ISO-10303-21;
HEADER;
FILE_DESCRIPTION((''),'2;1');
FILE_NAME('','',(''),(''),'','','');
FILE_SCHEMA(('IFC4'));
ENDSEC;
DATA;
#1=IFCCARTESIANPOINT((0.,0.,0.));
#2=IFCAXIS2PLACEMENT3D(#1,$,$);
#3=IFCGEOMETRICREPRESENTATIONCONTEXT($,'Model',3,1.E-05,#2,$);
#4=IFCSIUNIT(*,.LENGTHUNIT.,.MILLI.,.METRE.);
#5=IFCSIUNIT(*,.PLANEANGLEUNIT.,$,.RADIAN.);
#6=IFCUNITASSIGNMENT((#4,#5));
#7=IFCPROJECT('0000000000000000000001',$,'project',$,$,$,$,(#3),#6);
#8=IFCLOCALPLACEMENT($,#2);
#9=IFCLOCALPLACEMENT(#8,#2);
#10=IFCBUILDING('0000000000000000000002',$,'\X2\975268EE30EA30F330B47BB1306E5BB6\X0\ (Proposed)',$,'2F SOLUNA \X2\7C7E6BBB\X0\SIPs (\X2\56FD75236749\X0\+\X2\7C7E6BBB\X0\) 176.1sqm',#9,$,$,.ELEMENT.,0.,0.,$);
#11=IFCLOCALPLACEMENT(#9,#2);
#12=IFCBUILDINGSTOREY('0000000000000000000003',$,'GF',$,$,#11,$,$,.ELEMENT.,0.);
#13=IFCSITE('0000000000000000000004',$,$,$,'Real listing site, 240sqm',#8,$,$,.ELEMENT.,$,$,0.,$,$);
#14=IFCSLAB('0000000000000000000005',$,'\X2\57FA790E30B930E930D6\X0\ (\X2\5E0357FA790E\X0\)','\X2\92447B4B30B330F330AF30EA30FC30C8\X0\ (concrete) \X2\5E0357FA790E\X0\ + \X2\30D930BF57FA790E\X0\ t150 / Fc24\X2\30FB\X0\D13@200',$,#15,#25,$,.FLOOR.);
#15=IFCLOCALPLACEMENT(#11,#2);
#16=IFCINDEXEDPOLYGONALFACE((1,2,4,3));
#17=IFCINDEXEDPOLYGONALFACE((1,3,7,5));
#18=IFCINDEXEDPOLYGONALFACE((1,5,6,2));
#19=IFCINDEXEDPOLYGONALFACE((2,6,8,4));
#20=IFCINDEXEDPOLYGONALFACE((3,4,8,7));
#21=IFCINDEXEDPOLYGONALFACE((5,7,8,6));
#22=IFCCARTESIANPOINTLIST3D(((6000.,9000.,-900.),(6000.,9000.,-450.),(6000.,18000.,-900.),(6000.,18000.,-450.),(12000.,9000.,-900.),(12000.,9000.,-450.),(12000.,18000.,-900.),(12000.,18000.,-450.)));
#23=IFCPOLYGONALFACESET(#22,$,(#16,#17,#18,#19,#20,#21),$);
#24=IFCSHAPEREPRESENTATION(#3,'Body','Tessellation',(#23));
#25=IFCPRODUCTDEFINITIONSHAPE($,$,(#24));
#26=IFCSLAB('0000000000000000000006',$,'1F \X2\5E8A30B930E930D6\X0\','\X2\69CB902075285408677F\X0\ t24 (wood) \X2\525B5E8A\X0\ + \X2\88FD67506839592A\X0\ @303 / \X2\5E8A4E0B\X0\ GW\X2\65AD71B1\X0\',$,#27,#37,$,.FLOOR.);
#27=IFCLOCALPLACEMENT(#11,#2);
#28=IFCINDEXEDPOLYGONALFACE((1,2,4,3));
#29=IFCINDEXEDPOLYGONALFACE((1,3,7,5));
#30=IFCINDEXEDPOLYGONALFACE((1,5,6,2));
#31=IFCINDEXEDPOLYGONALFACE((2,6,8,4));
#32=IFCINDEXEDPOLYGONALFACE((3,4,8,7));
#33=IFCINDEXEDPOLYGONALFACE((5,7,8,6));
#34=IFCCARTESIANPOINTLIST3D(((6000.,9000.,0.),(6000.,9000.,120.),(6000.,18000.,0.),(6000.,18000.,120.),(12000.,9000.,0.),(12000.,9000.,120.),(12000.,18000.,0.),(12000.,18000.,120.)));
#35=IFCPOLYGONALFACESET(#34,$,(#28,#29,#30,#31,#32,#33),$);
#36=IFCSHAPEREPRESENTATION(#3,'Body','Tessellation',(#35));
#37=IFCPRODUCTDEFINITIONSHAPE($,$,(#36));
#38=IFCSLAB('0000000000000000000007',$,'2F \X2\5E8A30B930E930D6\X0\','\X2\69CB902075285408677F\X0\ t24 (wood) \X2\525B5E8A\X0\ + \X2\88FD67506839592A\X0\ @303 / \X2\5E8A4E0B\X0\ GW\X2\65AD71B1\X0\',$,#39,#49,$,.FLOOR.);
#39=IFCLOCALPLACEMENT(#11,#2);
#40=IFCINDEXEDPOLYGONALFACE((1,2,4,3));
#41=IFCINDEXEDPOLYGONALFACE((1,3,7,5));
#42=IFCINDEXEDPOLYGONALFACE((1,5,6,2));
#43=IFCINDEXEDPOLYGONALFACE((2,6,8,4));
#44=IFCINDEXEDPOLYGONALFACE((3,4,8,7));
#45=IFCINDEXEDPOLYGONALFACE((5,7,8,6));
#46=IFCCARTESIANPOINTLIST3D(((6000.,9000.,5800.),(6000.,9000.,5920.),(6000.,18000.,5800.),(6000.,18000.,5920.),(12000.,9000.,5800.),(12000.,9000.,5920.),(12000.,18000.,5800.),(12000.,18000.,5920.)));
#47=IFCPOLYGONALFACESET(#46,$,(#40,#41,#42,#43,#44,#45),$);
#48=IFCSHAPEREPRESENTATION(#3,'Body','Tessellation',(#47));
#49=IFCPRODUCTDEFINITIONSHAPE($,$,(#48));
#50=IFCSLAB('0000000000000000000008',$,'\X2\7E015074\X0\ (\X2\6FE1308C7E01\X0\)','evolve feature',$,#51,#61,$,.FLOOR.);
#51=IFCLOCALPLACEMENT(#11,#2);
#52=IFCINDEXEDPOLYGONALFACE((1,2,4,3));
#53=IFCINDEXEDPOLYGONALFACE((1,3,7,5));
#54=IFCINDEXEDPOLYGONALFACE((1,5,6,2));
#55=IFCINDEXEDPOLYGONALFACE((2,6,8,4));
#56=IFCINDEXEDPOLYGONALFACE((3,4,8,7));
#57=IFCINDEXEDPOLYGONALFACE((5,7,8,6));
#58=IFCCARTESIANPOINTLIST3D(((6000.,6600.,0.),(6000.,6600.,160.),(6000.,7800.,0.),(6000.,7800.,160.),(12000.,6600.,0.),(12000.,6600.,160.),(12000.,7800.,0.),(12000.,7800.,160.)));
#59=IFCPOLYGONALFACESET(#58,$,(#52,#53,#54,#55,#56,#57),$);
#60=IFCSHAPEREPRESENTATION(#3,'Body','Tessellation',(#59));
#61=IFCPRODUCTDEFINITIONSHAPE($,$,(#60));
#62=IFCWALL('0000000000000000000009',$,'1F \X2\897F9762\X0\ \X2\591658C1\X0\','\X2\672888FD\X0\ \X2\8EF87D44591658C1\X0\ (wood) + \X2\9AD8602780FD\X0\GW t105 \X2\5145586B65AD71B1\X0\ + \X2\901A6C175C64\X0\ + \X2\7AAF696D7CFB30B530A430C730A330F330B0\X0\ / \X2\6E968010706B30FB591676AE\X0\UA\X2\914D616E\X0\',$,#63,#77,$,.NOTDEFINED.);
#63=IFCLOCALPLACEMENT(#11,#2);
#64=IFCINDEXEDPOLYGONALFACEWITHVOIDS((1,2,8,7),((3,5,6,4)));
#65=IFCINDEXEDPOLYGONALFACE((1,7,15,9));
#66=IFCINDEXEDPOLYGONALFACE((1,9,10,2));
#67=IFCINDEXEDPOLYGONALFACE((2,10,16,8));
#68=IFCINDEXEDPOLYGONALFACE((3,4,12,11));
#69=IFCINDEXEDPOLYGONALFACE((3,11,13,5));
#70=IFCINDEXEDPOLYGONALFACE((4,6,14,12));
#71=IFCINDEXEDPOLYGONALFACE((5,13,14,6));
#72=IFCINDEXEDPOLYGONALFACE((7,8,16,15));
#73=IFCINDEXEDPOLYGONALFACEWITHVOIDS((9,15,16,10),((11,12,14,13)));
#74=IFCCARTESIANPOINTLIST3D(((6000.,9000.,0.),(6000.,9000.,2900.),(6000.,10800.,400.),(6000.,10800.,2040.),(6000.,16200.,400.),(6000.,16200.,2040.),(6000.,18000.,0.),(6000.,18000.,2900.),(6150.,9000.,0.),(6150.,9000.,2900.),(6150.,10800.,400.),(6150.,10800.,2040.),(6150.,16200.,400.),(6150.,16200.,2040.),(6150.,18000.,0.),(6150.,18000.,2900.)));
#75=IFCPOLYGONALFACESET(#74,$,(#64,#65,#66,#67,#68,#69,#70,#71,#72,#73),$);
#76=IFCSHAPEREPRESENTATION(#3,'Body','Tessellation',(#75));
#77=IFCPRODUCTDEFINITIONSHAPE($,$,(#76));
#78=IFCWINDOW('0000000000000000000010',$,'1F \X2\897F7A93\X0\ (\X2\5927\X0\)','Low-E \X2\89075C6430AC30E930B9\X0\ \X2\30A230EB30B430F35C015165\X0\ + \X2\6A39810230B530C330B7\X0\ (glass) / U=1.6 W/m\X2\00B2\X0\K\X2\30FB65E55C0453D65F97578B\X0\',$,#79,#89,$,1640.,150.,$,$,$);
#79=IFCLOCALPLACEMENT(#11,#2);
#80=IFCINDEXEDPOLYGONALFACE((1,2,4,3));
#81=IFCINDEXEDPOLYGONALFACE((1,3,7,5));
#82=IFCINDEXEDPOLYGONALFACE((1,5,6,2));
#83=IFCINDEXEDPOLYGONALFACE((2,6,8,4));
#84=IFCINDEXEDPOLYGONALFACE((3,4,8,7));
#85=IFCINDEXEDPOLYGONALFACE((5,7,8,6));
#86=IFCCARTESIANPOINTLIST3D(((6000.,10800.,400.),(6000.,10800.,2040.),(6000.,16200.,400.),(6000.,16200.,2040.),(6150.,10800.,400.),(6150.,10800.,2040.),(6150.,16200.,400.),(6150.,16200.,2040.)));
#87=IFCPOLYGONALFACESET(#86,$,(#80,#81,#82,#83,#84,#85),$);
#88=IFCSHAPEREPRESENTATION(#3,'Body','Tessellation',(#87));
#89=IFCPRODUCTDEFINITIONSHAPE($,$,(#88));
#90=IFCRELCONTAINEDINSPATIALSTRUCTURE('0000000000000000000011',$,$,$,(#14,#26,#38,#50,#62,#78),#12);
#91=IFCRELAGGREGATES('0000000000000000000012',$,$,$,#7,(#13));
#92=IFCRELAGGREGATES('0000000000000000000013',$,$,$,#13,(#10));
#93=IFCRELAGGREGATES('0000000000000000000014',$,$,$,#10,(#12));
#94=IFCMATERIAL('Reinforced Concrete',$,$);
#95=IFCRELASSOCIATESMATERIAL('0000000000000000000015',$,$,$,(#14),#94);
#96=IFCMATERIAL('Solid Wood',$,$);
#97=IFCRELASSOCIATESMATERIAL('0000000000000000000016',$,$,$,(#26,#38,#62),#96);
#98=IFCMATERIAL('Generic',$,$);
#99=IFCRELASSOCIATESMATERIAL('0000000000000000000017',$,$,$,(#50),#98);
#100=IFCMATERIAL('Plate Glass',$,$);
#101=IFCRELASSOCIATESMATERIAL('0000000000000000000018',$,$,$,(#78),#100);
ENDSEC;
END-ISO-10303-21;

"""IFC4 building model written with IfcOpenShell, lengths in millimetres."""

from ifc_helpers import new_model, si_unit, frame, frame_2d, origin, place, context, project, spatial, rectangle, extrude, material, element, fill, save


model = new_model("IFC4")

# Units and contexts
model_context = context("Model", 3, precision=1e-05, world=origin())
ifc_project = project(units=[si_unit("LENGTHUNIT", "METRE", prefix="MILLI"), si_unit("PLANEANGLEUNIT", "RADIAN")], contexts=[model_context])

# Site, building, storey
site_placement = place(None, origin())
site = spatial("IfcSite", under=ifc_project, at=site_placement, ObjectType="Real listing site, 240sqm", CompositionType="ELEMENT", RefElevation=0.0)
building_placement = place(site_placement, origin())
building = spatial("IfcBuilding", under=site, at=building_placement, Name="青森リンゴ箱の家 (Proposed)", ObjectType="2F SOLUNA 籾殻SIPs (国産杉+籾殻) 176.1sqm", CompositionType="ELEMENT", ElevationOfRefHeight=0.0, ElevationOfTerrain=0.0)
storey_placement = place(building_placement, origin())
storey = spatial("IfcBuildingStorey", under=building, at=storey_placement, Name="GF", CompositionType="ELEMENT", Elevation=0.0)

# Slabs
ifc_material_1 = material(Name="Reinforced Concrete")
slab_1_placement = place(storey_placement, frame((3000.0, 4500.0, -450.0)))
element("IfcSlab", 1, at=slab_1_placement, inside=storey, material=ifc_material_1, Name="基礎スラブ (布基礎)", Description="鉄筋コンクリート (concrete) 布基礎 + ベタ基礎 t150 / Fc24・D13@200", PredefinedType="FLOOR", context=model_context, shape_type="SweptSolid", body=[
    extrude(rectangle(XDim=6000.0, YDim=9000.0, at=frame_2d((3000.0, 4500.0))), frame((3000.0, 4500.0, -450.0)), (0.0, 0.0, 1.0), 450.0),
])
ifc_material_2 = material(Name="Solid Wood")
slab_2_placement = place(storey_placement, frame((3000.0, 4500.0, 0.0)))
element("IfcSlab", 2, at=slab_2_placement, inside=storey, material=ifc_material_2, Name="1F 床スラブ", Description="構造用合板 t24 (wood) 剛床 + 製材根太 @303 / 床下 GW断熱", PredefinedType="FLOOR", context=model_context, shape_type="SweptSolid", body=[
    extrude(rectangle(XDim=6000.0, YDim=9000.0, at=frame_2d((3000.0, 4500.0))), frame((3000.0, 4500.0, 0.0)), (0.0, 0.0, 1.0), 120.0),
])
slab_3_placement = place(storey_placement, frame((3000.0, 4500.0, 2900.0)))
element("IfcSlab", 3, at=slab_3_placement, inside=storey, material=ifc_material_2, Name="2F 床スラブ", Description="構造用合板 t24 (wood) 剛床 + 製材根太 @303 / 床下 GW断熱", PredefinedType="FLOOR", context=model_context, shape_type="SweptSolid", body=[
    extrude(rectangle(XDim=6000.0, YDim=9000.0, at=frame_2d((3000.0, 4500.0))), frame((3000.0, 4500.0, 2900.0)), (0.0, 0.0, 1.0), 120.0),
])
ifc_material_3 = material(Name="Generic")
slab_4_placement = place(storey_placement, frame((3000.0, 3300.0, 0.0)))
element("IfcSlab", 4, at=slab_4_placement, inside=storey, material=ifc_material_3, Name="縁側 (濡れ縁)", Description="evolve feature", PredefinedType="FLOOR", context=model_context, shape_type="SweptSolid", body=[
    extrude(rectangle(XDim=6000.0, YDim=1200.0, at=frame_2d((3000.0, 600.0))), frame((3000.0, 3300.0, 0.0)), (0.0, 0.0, 1.0), 160.0),
])

# Shared definitions
ifc_material_4 = material(Name="Plate Glass")

# Wall, opening, window
wall_1_placement = place(storey_placement, frame((3000.0, 4500.0, 0.0)))
wall_1 = element("IfcWall", 5, at=wall_1_placement, inside=storey, material=ifc_material_2, Name="1F 西面 外壁", Description="木製 軸組外壁 (wood) + 高性能GW t105 充填断熱 + 通気層 + 窯業系サイディング / 準耐火・外皮UA配慮", PredefinedType="NOTDEFINED", context=model_context, shape_type="SweptSolid", body=[
    extrude(rectangle(XDim=150.0, YDim=9000.0, at=frame_2d((75.0, 4500.0))), frame((3000.0, 4500.0, 0.0)), (0.0, 0.0, 1.0), 2900.0),
])
opening_1_placement = place(storey_placement, frame((3000.0, 5400.0, 200.0)))
opening_1 = element("IfcOpeningElement", 6, at=opening_1_placement, cuts=wall_1, PredefinedType="NOTDEFINED", context=model_context, shape_type="SweptSolid", body=[
    extrude(rectangle(XDim=150.0, YDim=5400.0, at=frame_2d((75.0, 2700.0))), frame((3000.0, 5400.0, 200.0)), (0.0, 0.0, 1.0), 1640.0),
])
window_1_placement = place(storey_placement, frame((3000.0, 5400.0, 200.0)))
window_1 = element("IfcWindow", 7, at=window_1_placement, inside=storey, material=ifc_material_4, Name="1F 西窓 (大)", Description="Low-E 複層ガラス アルゴン封入 + 樹脂サッシ (glass) / U=1.6 W/m²K・日射取得型", OverallHeight=1640.0, OverallWidth=150.0, context=model_context, shape_type="SweptSolid", body=[
    extrude(rectangle(XDim=150.0, YDim=5400.0, at=frame_2d((75.0, 2700.0))), frame((3000.0, 5400.0, 200.0)), (0.0, 0.0, 1.0), 1640.0),
])
fill(opening_1, window_1)

save(model, "model.ifc")
